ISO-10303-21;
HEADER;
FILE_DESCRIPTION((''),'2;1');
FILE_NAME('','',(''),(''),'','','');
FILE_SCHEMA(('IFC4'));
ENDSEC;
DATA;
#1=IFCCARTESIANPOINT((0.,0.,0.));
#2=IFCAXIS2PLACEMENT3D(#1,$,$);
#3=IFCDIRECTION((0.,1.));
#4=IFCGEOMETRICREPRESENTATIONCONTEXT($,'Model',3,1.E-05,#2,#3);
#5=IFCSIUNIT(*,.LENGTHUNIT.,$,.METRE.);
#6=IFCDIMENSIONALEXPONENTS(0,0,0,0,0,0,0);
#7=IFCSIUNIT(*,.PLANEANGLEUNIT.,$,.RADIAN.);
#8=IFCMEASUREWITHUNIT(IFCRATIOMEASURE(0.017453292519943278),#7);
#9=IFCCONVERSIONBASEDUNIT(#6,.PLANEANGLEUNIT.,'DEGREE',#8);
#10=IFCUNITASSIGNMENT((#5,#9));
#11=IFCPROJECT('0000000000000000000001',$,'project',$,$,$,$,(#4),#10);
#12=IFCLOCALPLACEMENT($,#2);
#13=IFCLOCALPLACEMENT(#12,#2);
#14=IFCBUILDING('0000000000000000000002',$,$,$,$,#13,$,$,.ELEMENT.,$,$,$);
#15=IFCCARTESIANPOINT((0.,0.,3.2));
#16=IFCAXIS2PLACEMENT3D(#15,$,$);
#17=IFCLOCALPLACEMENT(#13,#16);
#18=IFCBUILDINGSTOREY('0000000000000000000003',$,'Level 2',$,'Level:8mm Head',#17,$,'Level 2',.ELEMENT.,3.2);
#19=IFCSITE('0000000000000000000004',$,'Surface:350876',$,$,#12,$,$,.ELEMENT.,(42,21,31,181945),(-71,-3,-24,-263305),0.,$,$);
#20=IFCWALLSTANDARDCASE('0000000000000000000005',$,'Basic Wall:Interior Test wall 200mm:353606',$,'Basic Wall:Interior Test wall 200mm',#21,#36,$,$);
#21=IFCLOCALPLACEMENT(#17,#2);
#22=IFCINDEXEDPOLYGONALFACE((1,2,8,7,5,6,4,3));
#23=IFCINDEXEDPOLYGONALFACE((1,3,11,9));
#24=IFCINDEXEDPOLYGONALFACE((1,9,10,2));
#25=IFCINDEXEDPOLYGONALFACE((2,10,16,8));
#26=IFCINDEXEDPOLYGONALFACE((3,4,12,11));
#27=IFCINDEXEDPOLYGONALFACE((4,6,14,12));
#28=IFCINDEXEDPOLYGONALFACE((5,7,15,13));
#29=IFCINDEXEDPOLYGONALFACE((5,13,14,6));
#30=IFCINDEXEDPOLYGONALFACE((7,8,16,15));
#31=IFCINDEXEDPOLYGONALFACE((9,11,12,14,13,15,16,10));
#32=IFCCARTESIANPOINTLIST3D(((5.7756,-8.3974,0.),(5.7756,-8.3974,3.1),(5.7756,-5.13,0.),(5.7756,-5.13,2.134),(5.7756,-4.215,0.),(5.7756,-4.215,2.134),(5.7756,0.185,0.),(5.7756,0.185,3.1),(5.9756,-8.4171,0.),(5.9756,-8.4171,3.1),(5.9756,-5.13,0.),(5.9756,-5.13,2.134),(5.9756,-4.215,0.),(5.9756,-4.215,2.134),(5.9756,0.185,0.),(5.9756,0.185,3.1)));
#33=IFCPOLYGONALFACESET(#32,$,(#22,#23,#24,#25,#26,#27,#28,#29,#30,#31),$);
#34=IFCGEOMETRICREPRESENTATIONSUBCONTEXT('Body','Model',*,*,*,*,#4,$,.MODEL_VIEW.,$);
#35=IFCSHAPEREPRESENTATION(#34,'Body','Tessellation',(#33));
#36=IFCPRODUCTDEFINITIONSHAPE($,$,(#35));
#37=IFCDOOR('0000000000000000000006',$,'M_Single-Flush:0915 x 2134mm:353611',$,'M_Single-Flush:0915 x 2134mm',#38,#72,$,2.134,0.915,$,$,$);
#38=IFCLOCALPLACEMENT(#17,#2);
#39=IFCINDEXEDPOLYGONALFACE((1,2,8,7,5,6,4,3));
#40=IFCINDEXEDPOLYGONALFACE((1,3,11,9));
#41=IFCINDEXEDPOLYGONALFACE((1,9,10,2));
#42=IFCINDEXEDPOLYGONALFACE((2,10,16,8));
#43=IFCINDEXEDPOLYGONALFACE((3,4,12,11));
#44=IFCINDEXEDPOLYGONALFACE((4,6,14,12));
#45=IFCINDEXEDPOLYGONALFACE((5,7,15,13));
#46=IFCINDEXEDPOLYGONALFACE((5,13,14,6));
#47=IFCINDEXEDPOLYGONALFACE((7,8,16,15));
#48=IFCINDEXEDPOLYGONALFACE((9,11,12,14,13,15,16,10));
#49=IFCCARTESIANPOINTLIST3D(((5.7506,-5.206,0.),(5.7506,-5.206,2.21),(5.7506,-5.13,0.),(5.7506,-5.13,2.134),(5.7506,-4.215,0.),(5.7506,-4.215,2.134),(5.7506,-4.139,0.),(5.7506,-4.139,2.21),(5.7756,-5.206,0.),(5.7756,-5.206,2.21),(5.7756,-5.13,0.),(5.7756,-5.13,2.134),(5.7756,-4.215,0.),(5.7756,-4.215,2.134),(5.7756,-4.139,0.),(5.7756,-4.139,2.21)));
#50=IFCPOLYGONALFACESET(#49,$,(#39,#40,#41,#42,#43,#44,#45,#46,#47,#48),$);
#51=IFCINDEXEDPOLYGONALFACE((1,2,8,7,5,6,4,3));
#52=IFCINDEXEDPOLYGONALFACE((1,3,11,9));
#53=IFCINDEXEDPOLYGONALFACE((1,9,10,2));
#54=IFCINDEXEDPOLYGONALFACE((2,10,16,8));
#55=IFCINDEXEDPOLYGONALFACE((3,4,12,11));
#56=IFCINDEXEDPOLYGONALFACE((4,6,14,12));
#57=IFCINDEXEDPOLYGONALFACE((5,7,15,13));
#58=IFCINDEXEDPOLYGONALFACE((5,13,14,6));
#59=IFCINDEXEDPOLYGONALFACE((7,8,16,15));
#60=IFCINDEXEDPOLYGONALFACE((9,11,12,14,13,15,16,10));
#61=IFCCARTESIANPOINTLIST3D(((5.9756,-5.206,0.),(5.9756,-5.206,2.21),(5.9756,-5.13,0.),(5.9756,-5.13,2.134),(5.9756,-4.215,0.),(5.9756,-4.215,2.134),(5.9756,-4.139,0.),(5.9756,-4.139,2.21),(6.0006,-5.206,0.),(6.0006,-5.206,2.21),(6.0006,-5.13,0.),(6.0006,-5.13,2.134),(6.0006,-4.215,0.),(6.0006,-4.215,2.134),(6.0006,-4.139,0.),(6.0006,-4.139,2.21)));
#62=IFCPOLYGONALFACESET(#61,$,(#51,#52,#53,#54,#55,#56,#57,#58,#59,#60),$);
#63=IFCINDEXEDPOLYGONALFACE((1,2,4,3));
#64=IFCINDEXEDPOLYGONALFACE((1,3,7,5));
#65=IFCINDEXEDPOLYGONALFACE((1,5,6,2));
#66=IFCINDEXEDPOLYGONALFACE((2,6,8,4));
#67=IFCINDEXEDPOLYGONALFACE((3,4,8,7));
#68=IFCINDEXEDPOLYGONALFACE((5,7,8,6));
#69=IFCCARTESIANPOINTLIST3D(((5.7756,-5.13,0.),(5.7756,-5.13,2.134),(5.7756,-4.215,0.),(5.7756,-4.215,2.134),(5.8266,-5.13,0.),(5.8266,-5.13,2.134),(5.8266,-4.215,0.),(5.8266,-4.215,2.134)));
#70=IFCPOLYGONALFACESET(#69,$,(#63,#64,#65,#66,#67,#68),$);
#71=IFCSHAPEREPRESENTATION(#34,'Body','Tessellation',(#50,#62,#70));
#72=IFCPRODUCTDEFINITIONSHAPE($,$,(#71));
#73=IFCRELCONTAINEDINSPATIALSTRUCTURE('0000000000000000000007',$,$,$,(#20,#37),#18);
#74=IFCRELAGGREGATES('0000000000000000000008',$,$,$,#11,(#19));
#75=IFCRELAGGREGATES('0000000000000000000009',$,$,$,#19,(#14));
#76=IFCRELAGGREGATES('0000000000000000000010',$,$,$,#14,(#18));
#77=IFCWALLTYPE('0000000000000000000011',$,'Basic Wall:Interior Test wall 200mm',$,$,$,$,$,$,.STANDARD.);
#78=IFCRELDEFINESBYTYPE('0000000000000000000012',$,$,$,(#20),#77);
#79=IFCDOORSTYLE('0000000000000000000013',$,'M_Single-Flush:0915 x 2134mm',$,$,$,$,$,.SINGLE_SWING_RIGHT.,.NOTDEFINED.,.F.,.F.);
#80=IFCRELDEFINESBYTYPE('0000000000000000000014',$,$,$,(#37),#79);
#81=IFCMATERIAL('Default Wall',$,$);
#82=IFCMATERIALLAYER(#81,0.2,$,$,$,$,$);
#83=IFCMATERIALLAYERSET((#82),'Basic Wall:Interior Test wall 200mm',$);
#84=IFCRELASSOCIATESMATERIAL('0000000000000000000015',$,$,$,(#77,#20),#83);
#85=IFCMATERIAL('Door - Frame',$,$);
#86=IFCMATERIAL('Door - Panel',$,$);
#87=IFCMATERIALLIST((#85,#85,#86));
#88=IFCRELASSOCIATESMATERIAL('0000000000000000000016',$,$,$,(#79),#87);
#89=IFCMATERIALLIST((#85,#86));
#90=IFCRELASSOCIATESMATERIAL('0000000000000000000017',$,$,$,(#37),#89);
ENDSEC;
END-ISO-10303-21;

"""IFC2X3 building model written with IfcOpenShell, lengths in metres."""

from ifc_helpers import new_model, entity, si_unit, converted_unit, direction, frame, frame_2d, origin, place, context, subcontext, project, spatial, polyline, rectangle, outline, extrude, source, transform, mapped, material, material_list, layer, layer_set, layer_usage, type_object, type_shapes, element, fill, save


model = new_model("IFC2X3")

# Units and contexts
model_context = context("Model", 3, precision=1e-05, world=origin(), true_north=direction((0.0, 1.0)))
body_context = subcontext(model_context, "Body", "Model", "MODEL_VIEW")
ifc_project = project(units=[si_unit("LENGTHUNIT", "METRE"), converted_unit("PLANEANGLEUNIT", "DEGREE", entity("IfcRatioMeasure", 0.017453292519943278), si_unit("PLANEANGLEUNIT", "RADIAN"), dimensions=[0, 0, 0, 0, 0, 0, 0])], contexts=[model_context])

# Site, building, storey
site_placement = place(None, origin())
site = spatial("IfcSite", under=ifc_project, at=site_placement, Name="Surface:350876", CompositionType="ELEMENT", RefLatitude=(42, 21, 31, 181945), RefLongitude=(-71, -3, -24, -263305), RefElevation=0.0)
building_placement = place(site_placement, origin())
building = spatial("IfcBuilding", under=site, at=building_placement, CompositionType="ELEMENT")
storey_placement = place(building_placement, frame((0.0, 0.0, 3.2)))
storey = spatial("IfcBuildingStorey", under=building, at=storey_placement, Name="Level 2", ObjectType="Level:8mm Head", LongName="Level 2", CompositionType="ELEMENT", Elevation=3.2)

# Shared definitions
ifc_material_1 = material(Name="Default Wall")

# Shared definitions
ifc_layer_1 = layer(ifc_material_1, 0.2)
ifc_layer_set_1 = layer_set([ifc_layer_1], Name="Basic Wall:Interior Test wall 200mm")
wall_type_1 = type_object("IfcWallType", Name="Basic Wall:Interior Test wall 200mm", PredefinedType="STANDARD", material=ifc_layer_set_1)

# Wall, opening, door
ifc_layer_usage_1 = layer_usage(ifc_layer_set_1, "AXIS2", "NEGATIVE", 0.1)
wall_1_placement = place(storey_placement, frame((5.8756, -8.4171, 0.0), z_axis=(0.0, 0.0, 1.0), x_axis=(0.0, 1.0, 0.0)))
wall_1 = element("IfcWallStandardCase", 1, at=wall_1_placement, inside=storey, type_object=wall_type_1, material=ifc_layer_usage_1, Name="Basic Wall:Interior Test wall 200mm:353606", ObjectType="Basic Wall:Interior Test wall 200mm", context=body_context, shape_type="SweptSolid", body=[
    extrude(outline(polyline([(0.0, -0.1), (8.6021, -0.1), (8.6021, 0.1), (4.5021, 0.1), (4.3021, 0.1), (0.0197, 0.1), (0.0, -0.1)])), origin(), (0.0, 0.0, 1.0), 3.1),
])
opening_1_placement = place(wall_1_placement, frame((3.2871, -0.1, 0.0)))
opening_1 = element("IfcOpeningElement", 2, at=opening_1_placement, cuts=wall_1, ObjectType="Opening", context=body_context, shape_type="SweptSolid", body=[
    extrude(rectangle(XDim=0.915, YDim=2.134, at=frame_2d((1.067, 0.4575), x_axis=(0.0, 1.0))), frame((0.0, 0.0, 0.0), z_axis=(0.0, 1.0, 0.0), x_axis=(0.0, 0.0, 1.0)), (0.0, 0.0, 1.0), 0.2),
])
ifc_material_2 = material(Name="Door - Frame")
ifc_material_3 = material(Name="Door - Panel")
ifc_material_list_1 = material_list([ifc_material_2, ifc_material_3])
ifc_material_list_2 = material_list([ifc_material_2, ifc_material_2, ifc_material_3])
door_style = type_object("IfcDoorStyle", Name="M_Single-Flush:0915 x 2134mm", ConstructionType="NOTDEFINED", OperationType="SINGLE_SWING_RIGHT", ParameterTakesPrecedence=False, Sizeable=False, material=ifc_material_list_2)
shared_shape_1 = source(origin(), body_context, "Body", "SweptSolid", [
    extrude(outline(polyline([(-0.5335, -1.124), (0.5335, -1.124), (0.5335, 1.086), (0.4575, 1.086), (0.4575, -1.048), (-0.4575, -1.048), (-0.4575, 1.086), (-0.5335, 1.086), (-0.5335, -1.124)])), frame((0.4575, 0.2, 1.086), z_axis=(0.0, 1.0, 0.0), x_axis=(1.0, 0.0, 0.0)), (0.0, 0.0, 1.0), 0.025),
    extrude(outline(polyline([(-1.124, -0.5335), (1.086, -0.5335), (1.086, -0.4575), (-1.048, -0.4575), (-1.048, 0.4575), (1.086, 0.4575), (1.086, 0.5335), (-1.124, 0.5335), (-1.124, -0.5335)])), frame((0.4575, -0.025, 1.086), z_axis=(0.0, 1.0, 0.0), x_axis=(0.0, 0.0, -1.0)), (0.0, 0.0, 1.0), 0.025),
    extrude(rectangle(XDim=0.051, YDim=0.915, at=frame_2d((0.0, 0.0), x_axis=(1.0, 0.0))), frame((0.4575, 0.1745, 0.0), z_axis=(0.0, 0.0, 1.0), x_axis=(0.0, 1.0, 0.0)), (0.0, 0.0, 1.0), 2.134),
])
type_shapes(door_style, [shared_shape_1])
door_placement = place(opening_1_placement, origin())
door = element("IfcDoor", 3, at=door_placement, inside=storey, type_object=door_style, material=ifc_material_list_1, Name="M_Single-Flush:0915 x 2134mm:353611", ObjectType="M_Single-Flush:0915 x 2134mm", OverallHeight=2.134, OverallWidth=0.915, context=body_context, shape_type="MappedRepresentation", body=[
    mapped(shared_shape_1, transform((0.0, 0.0, 0.0), scale=1.0)),
])
fill(opening_1, door)

save(model, "model.ifc")
